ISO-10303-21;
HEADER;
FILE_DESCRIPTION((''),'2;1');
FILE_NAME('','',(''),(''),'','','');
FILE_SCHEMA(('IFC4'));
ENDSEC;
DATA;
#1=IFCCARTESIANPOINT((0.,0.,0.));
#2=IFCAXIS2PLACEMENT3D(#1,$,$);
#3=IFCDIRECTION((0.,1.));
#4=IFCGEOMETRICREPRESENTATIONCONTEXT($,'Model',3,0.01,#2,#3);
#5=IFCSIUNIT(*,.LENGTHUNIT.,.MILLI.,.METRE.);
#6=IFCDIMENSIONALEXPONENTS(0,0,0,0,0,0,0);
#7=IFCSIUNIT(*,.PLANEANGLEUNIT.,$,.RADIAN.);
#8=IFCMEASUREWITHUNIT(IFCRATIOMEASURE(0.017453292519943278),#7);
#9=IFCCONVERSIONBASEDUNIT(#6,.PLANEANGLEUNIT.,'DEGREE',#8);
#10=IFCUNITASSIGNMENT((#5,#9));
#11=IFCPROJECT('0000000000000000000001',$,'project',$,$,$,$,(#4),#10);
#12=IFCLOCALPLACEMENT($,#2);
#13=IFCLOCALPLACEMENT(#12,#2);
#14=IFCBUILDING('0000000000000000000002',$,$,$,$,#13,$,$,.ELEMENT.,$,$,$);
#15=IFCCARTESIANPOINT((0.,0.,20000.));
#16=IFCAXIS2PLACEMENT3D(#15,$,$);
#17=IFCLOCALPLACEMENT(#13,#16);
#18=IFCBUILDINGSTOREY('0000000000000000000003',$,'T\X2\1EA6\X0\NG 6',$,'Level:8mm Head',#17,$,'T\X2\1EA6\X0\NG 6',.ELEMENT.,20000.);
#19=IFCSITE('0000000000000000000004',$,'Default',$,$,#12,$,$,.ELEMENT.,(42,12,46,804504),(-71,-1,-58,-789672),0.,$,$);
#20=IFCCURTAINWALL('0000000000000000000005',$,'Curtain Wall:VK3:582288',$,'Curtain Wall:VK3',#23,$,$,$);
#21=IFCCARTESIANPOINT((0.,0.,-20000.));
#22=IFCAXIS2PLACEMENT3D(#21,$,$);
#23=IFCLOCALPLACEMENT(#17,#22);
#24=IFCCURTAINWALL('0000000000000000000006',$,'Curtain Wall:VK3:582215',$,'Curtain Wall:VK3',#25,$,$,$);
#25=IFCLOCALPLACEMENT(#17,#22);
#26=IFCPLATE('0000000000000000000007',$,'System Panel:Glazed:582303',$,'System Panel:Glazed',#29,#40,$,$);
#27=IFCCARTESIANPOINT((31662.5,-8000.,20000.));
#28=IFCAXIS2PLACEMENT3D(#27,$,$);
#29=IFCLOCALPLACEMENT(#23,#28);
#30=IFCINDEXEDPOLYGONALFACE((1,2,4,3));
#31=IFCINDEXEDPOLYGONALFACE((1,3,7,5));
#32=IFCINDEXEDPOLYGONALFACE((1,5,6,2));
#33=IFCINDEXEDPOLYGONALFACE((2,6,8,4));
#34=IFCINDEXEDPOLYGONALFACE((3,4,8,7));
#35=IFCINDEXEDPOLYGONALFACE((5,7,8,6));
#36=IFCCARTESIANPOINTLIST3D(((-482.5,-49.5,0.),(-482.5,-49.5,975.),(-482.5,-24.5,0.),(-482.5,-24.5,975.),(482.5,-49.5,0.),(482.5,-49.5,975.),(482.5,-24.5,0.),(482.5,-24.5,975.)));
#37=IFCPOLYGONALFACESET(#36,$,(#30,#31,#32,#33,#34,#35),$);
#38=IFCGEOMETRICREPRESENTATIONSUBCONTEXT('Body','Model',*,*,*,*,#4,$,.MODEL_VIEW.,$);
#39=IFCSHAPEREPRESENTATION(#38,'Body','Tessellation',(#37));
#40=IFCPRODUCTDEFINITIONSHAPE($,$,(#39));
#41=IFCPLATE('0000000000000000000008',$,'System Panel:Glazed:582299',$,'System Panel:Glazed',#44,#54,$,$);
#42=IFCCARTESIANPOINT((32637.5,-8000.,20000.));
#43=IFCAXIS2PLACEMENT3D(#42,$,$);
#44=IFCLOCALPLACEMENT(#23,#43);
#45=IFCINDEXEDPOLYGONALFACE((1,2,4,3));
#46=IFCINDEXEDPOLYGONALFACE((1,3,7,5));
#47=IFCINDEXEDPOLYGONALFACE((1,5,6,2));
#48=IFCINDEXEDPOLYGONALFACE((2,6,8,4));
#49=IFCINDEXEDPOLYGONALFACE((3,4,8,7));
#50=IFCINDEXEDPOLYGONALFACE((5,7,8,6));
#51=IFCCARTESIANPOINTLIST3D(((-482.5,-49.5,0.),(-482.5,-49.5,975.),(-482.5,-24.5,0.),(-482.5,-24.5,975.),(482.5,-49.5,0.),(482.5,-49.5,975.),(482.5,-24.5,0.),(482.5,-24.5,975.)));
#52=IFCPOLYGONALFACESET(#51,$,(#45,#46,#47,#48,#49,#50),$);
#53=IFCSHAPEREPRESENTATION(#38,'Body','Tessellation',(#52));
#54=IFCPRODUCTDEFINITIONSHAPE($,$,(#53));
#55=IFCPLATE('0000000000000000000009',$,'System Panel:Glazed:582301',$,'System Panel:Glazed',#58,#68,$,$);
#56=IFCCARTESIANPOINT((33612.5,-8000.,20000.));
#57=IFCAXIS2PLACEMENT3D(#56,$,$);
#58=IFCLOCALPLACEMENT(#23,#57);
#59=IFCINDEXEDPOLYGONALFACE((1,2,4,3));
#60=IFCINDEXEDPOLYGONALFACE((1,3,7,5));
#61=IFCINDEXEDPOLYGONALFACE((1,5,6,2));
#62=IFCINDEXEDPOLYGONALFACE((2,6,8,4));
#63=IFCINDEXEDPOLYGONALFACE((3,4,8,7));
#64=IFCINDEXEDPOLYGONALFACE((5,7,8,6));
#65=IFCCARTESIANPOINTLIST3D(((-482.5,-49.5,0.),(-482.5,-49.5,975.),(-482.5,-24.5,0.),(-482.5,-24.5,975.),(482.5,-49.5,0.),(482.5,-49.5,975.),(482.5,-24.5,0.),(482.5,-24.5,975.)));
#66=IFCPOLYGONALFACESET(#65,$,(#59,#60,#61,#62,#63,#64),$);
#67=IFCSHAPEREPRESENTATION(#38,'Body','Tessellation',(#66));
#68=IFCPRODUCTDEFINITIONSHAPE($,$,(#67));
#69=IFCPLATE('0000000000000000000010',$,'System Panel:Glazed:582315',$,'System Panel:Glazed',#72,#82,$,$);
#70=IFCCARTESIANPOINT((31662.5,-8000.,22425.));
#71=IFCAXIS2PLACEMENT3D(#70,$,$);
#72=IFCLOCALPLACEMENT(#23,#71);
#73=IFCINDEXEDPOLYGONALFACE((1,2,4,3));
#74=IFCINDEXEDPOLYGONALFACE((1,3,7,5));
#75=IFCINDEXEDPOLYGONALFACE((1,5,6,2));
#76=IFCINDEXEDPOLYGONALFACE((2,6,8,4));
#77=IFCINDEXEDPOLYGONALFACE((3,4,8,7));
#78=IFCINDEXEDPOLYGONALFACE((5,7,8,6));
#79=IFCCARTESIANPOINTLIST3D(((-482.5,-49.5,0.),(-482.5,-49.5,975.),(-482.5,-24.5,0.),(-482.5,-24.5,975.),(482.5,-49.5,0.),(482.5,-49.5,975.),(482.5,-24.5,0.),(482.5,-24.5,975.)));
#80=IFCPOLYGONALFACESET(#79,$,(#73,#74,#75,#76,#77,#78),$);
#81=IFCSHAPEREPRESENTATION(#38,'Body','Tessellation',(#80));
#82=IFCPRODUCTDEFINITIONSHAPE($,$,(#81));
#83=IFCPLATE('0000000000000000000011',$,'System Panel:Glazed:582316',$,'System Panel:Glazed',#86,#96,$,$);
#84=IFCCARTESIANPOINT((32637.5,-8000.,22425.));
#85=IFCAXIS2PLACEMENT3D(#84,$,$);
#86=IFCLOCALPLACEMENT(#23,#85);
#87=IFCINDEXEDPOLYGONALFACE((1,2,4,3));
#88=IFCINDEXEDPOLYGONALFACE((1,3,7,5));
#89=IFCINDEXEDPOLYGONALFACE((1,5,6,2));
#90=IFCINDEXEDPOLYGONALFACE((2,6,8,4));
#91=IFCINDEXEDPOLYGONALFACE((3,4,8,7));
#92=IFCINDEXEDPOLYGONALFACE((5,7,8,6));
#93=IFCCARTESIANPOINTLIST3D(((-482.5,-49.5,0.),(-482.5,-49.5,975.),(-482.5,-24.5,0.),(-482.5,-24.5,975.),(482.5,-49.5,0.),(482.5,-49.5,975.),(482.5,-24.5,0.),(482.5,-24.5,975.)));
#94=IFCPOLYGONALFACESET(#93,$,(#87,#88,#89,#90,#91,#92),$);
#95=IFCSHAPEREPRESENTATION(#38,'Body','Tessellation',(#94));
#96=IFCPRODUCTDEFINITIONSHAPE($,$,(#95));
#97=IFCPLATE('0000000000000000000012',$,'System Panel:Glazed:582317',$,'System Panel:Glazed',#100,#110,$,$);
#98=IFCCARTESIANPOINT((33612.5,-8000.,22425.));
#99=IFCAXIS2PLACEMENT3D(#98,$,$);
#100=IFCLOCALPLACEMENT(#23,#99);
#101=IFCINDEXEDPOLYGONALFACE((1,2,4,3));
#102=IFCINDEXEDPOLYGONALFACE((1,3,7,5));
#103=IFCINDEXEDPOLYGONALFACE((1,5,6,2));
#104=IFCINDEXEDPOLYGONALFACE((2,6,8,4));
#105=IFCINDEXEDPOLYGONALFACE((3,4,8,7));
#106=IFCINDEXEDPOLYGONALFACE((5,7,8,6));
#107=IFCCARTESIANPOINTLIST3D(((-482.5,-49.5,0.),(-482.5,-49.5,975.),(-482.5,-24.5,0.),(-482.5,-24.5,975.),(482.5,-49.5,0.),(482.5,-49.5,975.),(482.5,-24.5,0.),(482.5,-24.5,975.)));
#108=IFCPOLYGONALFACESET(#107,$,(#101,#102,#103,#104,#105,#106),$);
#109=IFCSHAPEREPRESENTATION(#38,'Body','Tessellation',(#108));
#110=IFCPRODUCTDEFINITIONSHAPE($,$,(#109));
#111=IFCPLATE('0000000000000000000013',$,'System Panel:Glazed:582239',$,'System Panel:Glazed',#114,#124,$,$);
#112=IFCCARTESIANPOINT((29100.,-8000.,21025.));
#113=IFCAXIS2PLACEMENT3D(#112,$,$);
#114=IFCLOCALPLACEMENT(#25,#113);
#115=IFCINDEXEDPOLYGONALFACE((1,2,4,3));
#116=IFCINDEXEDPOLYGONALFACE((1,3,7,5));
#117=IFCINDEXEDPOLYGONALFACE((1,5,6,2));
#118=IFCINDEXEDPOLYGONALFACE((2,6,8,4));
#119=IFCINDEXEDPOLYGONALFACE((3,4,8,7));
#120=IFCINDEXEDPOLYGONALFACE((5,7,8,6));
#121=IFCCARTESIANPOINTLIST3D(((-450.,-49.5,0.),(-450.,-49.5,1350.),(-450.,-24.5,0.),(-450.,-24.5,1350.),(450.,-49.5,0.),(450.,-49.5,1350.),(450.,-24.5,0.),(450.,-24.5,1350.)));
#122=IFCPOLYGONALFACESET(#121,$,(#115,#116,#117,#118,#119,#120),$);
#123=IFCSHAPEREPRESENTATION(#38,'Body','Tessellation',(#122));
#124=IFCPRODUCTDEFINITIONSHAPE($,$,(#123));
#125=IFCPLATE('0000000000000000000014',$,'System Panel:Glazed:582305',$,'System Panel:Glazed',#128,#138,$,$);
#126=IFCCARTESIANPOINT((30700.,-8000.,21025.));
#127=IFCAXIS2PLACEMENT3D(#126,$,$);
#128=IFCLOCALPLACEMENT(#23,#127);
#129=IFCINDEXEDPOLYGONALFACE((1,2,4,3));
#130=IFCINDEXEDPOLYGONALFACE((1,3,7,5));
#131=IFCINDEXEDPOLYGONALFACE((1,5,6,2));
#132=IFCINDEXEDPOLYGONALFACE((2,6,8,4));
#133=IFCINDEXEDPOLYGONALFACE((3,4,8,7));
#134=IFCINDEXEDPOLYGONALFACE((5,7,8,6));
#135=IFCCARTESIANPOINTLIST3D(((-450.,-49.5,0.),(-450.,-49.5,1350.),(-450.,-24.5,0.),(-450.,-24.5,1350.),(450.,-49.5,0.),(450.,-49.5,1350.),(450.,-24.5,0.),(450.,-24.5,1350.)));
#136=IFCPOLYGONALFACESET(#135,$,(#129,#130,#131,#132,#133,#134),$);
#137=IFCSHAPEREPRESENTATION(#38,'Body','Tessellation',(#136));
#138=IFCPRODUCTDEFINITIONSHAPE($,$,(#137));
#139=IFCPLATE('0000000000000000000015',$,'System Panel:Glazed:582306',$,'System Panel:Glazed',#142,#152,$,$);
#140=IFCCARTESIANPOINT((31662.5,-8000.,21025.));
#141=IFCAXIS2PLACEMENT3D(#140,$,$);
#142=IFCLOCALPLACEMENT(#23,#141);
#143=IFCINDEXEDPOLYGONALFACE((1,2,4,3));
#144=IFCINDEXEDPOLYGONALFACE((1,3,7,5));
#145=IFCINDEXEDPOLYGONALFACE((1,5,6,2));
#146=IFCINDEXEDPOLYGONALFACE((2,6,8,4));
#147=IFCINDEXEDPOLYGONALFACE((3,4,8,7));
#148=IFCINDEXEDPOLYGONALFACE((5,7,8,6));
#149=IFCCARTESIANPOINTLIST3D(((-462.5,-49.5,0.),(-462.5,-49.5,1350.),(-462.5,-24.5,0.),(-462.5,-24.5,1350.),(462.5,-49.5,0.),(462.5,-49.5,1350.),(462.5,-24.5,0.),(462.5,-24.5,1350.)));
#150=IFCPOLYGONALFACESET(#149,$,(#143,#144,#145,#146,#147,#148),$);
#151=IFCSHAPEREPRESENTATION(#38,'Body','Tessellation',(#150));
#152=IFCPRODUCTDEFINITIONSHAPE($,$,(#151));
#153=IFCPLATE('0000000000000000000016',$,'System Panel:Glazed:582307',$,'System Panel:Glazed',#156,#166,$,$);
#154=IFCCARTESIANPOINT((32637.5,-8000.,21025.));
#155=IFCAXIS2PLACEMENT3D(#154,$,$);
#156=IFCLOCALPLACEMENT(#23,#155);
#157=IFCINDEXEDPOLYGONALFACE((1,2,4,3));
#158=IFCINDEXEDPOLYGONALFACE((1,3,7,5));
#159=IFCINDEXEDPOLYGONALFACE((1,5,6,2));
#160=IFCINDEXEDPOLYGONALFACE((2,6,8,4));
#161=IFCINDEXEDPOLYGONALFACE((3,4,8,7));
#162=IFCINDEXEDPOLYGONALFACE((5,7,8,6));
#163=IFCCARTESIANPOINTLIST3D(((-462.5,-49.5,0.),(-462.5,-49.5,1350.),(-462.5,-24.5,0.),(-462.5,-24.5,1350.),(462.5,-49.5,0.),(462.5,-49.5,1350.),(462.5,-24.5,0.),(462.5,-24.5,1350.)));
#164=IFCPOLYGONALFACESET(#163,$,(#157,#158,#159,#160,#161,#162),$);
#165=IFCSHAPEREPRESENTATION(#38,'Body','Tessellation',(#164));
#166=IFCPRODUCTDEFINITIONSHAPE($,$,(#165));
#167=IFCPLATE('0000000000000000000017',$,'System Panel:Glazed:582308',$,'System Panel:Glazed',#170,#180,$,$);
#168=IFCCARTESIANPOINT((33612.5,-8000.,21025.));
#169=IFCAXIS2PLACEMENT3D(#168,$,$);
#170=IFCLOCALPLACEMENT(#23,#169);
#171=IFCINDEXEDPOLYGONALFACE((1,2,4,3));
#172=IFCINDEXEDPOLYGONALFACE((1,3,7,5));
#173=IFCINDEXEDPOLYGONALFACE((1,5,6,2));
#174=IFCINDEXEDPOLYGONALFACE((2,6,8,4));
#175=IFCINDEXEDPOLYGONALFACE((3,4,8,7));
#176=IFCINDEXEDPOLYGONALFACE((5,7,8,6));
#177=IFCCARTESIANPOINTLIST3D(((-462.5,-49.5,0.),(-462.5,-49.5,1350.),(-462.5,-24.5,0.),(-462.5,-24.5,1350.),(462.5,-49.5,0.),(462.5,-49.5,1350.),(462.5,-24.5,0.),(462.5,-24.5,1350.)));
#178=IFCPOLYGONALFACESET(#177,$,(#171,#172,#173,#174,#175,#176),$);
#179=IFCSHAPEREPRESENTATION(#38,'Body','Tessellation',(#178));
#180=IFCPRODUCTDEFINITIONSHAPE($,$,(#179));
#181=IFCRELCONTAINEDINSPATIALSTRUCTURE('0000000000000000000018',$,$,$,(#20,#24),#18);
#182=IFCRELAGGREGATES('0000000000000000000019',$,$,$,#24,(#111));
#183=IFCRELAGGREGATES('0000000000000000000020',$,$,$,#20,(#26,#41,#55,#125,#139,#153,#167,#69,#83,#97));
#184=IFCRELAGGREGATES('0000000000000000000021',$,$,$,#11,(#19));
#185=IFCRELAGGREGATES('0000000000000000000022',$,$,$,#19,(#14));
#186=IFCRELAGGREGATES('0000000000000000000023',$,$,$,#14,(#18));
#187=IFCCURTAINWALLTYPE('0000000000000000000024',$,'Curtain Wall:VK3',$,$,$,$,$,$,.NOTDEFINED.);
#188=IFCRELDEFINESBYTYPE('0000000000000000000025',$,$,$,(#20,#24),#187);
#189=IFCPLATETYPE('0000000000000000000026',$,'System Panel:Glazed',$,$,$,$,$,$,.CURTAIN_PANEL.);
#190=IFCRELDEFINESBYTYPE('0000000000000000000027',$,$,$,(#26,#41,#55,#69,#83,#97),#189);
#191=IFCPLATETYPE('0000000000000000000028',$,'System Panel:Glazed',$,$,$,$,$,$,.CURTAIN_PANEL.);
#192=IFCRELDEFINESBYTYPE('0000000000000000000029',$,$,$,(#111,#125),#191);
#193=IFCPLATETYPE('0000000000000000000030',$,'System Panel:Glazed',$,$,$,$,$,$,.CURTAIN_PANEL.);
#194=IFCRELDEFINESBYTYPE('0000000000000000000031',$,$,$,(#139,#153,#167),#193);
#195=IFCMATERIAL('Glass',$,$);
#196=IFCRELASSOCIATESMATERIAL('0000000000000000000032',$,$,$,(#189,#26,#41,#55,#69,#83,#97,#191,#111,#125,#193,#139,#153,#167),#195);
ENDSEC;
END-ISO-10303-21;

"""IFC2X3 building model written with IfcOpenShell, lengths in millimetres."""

from ifc_helpers import new_model, entity, si_unit, converted_unit, direction, frame, frame_2d, origin, place, context, subcontext, project, spatial, rectangle, extrude, source, transform, mapped, material, type_object, type_shapes, element, aggregate, save


model = new_model("IFC2X3")

# Units and contexts
model_context = context("Model", 3, precision=0.01, world=origin(), true_north=direction((0.0, 1.0)))
body_context = subcontext(model_context, "Body", "Model", "MODEL_VIEW")
ifc_project = project(units=[si_unit("LENGTHUNIT", "METRE", prefix="MILLI"), converted_unit("PLANEANGLEUNIT", "DEGREE", entity("IfcRatioMeasure", 0.017453292519943278), si_unit("PLANEANGLEUNIT", "RADIAN"), dimensions=[0, 0, 0, 0, 0, 0, 0])], contexts=[model_context])

# Site, building, storey
site_placement = place(None, origin())
site = spatial("IfcSite", under=ifc_project, at=site_placement, Name="Default", CompositionType="ELEMENT", RefLatitude=(42, 12, 46, 804504), RefLongitude=(-71, -1, -58, -789672), RefElevation=0.0)
building_placement = place(site_placement, origin())
building = spatial("IfcBuilding", under=site, at=building_placement, CompositionType="ELEMENT")
storey_placement = place(building_placement, frame((0.0, 0.0, 20000.0)))
storey = spatial("IfcBuildingStorey", under=building, at=storey_placement, Name="TẦNG 6", ObjectType="Level:8mm Head", LongName="TẦNG 6", CompositionType="ELEMENT", Elevation=20000.0)

# Curtain walls
curtain_wall_type = type_object("IfcCurtainWallType", Name="Curtain Wall:VK3", PredefinedType="NOTDEFINED")
curtain_wall_1_placement = place(storey_placement, frame((0.0, 0.0, -20000.0)))
curtain_wall_1 = element("IfcCurtainWall", 1, at=curtain_wall_1_placement, inside=storey, type_object=curtain_wall_type, Name="Curtain Wall:VK3:582288", ObjectType="Curtain Wall:VK3")
curtain_wall_2_placement = place(storey_placement, frame((0.0, 0.0, -20000.0)))
curtain_wall_2 = element("IfcCurtainWall", 2, at=curtain_wall_2_placement, inside=storey, type_object=curtain_wall_type, Name="Curtain Wall:VK3:582215", ObjectType="Curtain Wall:VK3")

# Plates
ifc_material_1 = material(Name="Glass")
plate_type_1 = type_object("IfcPlateType", Name="System Panel:Glazed", PredefinedType="CURTAIN_PANEL", material=ifc_material_1)
shared_shape_1 = source(origin(), body_context, "Body", "SweptSolid", [
    extrude(rectangle(XDim=25.0, YDim=965.0, at=frame_2d((0.0, 0.0), x_axis=(1.0, 0.0))), frame((0.0, -37.0, 0.0), z_axis=(0.0, 0.0, 1.0), x_axis=(0.0, 1.0, 0.0)), (0.0, 0.0, 1.0), 975.0),
])
type_shapes(plate_type_1, [shared_shape_1])
plate_1_placement = place(curtain_wall_1_placement, frame((31662.5, -8000.0, 20000.0)))
plate_1 = element("IfcPlate", 3, at=plate_1_placement, type_object=plate_type_1, material=ifc_material_1, Name="System Panel:Glazed:582303", ObjectType="System Panel:Glazed", context=body_context, shape_type="MappedRepresentation", body=[
    mapped(shared_shape_1, transform((0.0, 0.0, 0.0), scale=1.0)),
])
plate_2_placement = place(curtain_wall_1_placement, frame((32637.5, -8000.0, 20000.0)))
plate_2 = element("IfcPlate", 4, at=plate_2_placement, type_object=plate_type_1, material=ifc_material_1, Name="System Panel:Glazed:582299", ObjectType="System Panel:Glazed", context=body_context, shape_type="MappedRepresentation", body=[
    mapped(shared_shape_1, transform((0.0, 0.0, 0.0), scale=1.0)),
])
plate_3_placement = place(curtain_wall_1_placement, frame((33612.5, -8000.0, 20000.0)))
plate_3 = element("IfcPlate", 5, at=plate_3_placement, type_object=plate_type_1, material=ifc_material_1, Name="System Panel:Glazed:582301", ObjectType="System Panel:Glazed", context=body_context, shape_type="MappedRepresentation", body=[
    mapped(shared_shape_1, transform((0.0, 0.0, 0.0), scale=1.0)),
])
plate_4_placement = place(curtain_wall_1_placement, frame((31662.5, -8000.0, 22425.0)))
plate_4 = element("IfcPlate", 6, at=plate_4_placement, type_object=plate_type_1, material=ifc_material_1, Name="System Panel:Glazed:582315", ObjectType="System Panel:Glazed", context=body_context, shape_type="MappedRepresentation", body=[
    mapped(shared_shape_1, transform((0.0, 0.0, 0.0), scale=1.0)),
])
plate_5_placement = place(curtain_wall_1_placement, frame((32637.5, -8000.0, 22425.0)))
plate_5 = element("IfcPlate", 7, at=plate_5_placement, type_object=plate_type_1, material=ifc_material_1, Name="System Panel:Glazed:582316", ObjectType="System Panel:Glazed", context=body_context, shape_type="MappedRepresentation", body=[
    mapped(shared_shape_1, transform((0.0, 0.0, 0.0), scale=1.0)),
])
plate_6_placement = place(curtain_wall_1_placement, frame((33612.5, -8000.0, 22425.0)))
plate_6 = element("IfcPlate", 8, at=plate_6_placement, type_object=plate_type_1, material=ifc_material_1, Name="System Panel:Glazed:582317", ObjectType="System Panel:Glazed", context=body_context, shape_type="MappedRepresentation", body=[
    mapped(shared_shape_1, transform((0.0, 0.0, 0.0), scale=1.0)),
])
plate_type_2 = type_object("IfcPlateType", Name="System Panel:Glazed", PredefinedType="CURTAIN_PANEL", material=ifc_material_1)
shared_shape_2 = source(origin(), body_context, "Body", "SweptSolid", [
    extrude(rectangle(XDim=25.0, YDim=900.0, at=frame_2d((0.0, 0.0), x_axis=(1.0, 0.0))), frame((0.0, -37.0, 0.0), z_axis=(0.0, 0.0, 1.0), x_axis=(0.0, 1.0, 0.0)), (0.0, 0.0, 1.0), 1350.0),
])
type_shapes(plate_type_2, [shared_shape_2])
plate_7_placement = place(curtain_wall_2_placement, frame((29100.0, -8000.0, 21025.0)))
plate_7 = element("IfcPlate", 9, at=plate_7_placement, type_object=plate_type_2, material=ifc_material_1, Name="System Panel:Glazed:582239", ObjectType="System Panel:Glazed", context=body_context, shape_type="MappedRepresentation", body=[
    mapped(shared_shape_2, transform((0.0, 0.0, 0.0), scale=1.0)),
])
aggregate(curtain_wall_2, [plate_7])
plate_8_placement = place(curtain_wall_1_placement, frame((30700.0, -8000.0, 21025.0)))
plate_8 = element("IfcPlate", 10, at=plate_8_placement, type_object=plate_type_2, material=ifc_material_1, Name="System Panel:Glazed:582305", ObjectType="System Panel:Glazed", context=body_context, shape_type="MappedRepresentation", body=[
    mapped(shared_shape_2, transform((0.0, 0.0, 0.0), scale=1.0)),
])
plate_type_3 = type_object("IfcPlateType", Name="System Panel:Glazed", PredefinedType="CURTAIN_PANEL", material=ifc_material_1)
shared_shape_3 = source(origin(), body_context, "Body", "SweptSolid", [
    extrude(rectangle(XDim=25.0, YDim=925.0, at=frame_2d((0.0, 0.0), x_axis=(1.0, 0.0))), frame((0.0, -37.0, 0.0), z_axis=(0.0, 0.0, 1.0), x_axis=(0.0, 1.0, 0.0)), (0.0, 0.0, 1.0), 1350.0),
])
type_shapes(plate_type_3, [shared_shape_3])
plate_9_placement = place(curtain_wall_1_placement, frame((31662.5, -8000.0, 21025.0)))
plate_9 = element("IfcPlate", 11, at=plate_9_placement, type_object=plate_type_3, material=ifc_material_1, Name="System Panel:Glazed:582306", ObjectType="System Panel:Glazed", context=body_context, shape_type="MappedRepresentation", body=[
    mapped(shared_shape_3, transform((0.0, 0.0, 0.0), scale=1.0)),
])
plate_10_placement = place(curtain_wall_1_placement, frame((32637.5, -8000.0, 21025.0)))
plate_10 = element("IfcPlate", 12, at=plate_10_placement, type_object=plate_type_3, material=ifc_material_1, Name="System Panel:Glazed:582307", ObjectType="System Panel:Glazed", context=body_context, shape_type="MappedRepresentation", body=[
    mapped(shared_shape_3, transform((0.0, 0.0, 0.0), scale=1.0)),
])
plate_11_placement = place(curtain_wall_1_placement, frame((33612.5, -8000.0, 21025.0)))
plate_11 = element("IfcPlate", 13, at=plate_11_placement, type_object=plate_type_3, material=ifc_material_1, Name="System Panel:Glazed:582308", ObjectType="System Panel:Glazed", context=body_context, shape_type="MappedRepresentation", body=[
    mapped(shared_shape_3, transform((0.0, 0.0, 0.0), scale=1.0)),
])
aggregate(curtain_wall_1, [plate_1, plate_2, plate_3, plate_8, plate_9, plate_10, plate_11, plate_4, plate_5, plate_6])

save(model, "model.ifc")
